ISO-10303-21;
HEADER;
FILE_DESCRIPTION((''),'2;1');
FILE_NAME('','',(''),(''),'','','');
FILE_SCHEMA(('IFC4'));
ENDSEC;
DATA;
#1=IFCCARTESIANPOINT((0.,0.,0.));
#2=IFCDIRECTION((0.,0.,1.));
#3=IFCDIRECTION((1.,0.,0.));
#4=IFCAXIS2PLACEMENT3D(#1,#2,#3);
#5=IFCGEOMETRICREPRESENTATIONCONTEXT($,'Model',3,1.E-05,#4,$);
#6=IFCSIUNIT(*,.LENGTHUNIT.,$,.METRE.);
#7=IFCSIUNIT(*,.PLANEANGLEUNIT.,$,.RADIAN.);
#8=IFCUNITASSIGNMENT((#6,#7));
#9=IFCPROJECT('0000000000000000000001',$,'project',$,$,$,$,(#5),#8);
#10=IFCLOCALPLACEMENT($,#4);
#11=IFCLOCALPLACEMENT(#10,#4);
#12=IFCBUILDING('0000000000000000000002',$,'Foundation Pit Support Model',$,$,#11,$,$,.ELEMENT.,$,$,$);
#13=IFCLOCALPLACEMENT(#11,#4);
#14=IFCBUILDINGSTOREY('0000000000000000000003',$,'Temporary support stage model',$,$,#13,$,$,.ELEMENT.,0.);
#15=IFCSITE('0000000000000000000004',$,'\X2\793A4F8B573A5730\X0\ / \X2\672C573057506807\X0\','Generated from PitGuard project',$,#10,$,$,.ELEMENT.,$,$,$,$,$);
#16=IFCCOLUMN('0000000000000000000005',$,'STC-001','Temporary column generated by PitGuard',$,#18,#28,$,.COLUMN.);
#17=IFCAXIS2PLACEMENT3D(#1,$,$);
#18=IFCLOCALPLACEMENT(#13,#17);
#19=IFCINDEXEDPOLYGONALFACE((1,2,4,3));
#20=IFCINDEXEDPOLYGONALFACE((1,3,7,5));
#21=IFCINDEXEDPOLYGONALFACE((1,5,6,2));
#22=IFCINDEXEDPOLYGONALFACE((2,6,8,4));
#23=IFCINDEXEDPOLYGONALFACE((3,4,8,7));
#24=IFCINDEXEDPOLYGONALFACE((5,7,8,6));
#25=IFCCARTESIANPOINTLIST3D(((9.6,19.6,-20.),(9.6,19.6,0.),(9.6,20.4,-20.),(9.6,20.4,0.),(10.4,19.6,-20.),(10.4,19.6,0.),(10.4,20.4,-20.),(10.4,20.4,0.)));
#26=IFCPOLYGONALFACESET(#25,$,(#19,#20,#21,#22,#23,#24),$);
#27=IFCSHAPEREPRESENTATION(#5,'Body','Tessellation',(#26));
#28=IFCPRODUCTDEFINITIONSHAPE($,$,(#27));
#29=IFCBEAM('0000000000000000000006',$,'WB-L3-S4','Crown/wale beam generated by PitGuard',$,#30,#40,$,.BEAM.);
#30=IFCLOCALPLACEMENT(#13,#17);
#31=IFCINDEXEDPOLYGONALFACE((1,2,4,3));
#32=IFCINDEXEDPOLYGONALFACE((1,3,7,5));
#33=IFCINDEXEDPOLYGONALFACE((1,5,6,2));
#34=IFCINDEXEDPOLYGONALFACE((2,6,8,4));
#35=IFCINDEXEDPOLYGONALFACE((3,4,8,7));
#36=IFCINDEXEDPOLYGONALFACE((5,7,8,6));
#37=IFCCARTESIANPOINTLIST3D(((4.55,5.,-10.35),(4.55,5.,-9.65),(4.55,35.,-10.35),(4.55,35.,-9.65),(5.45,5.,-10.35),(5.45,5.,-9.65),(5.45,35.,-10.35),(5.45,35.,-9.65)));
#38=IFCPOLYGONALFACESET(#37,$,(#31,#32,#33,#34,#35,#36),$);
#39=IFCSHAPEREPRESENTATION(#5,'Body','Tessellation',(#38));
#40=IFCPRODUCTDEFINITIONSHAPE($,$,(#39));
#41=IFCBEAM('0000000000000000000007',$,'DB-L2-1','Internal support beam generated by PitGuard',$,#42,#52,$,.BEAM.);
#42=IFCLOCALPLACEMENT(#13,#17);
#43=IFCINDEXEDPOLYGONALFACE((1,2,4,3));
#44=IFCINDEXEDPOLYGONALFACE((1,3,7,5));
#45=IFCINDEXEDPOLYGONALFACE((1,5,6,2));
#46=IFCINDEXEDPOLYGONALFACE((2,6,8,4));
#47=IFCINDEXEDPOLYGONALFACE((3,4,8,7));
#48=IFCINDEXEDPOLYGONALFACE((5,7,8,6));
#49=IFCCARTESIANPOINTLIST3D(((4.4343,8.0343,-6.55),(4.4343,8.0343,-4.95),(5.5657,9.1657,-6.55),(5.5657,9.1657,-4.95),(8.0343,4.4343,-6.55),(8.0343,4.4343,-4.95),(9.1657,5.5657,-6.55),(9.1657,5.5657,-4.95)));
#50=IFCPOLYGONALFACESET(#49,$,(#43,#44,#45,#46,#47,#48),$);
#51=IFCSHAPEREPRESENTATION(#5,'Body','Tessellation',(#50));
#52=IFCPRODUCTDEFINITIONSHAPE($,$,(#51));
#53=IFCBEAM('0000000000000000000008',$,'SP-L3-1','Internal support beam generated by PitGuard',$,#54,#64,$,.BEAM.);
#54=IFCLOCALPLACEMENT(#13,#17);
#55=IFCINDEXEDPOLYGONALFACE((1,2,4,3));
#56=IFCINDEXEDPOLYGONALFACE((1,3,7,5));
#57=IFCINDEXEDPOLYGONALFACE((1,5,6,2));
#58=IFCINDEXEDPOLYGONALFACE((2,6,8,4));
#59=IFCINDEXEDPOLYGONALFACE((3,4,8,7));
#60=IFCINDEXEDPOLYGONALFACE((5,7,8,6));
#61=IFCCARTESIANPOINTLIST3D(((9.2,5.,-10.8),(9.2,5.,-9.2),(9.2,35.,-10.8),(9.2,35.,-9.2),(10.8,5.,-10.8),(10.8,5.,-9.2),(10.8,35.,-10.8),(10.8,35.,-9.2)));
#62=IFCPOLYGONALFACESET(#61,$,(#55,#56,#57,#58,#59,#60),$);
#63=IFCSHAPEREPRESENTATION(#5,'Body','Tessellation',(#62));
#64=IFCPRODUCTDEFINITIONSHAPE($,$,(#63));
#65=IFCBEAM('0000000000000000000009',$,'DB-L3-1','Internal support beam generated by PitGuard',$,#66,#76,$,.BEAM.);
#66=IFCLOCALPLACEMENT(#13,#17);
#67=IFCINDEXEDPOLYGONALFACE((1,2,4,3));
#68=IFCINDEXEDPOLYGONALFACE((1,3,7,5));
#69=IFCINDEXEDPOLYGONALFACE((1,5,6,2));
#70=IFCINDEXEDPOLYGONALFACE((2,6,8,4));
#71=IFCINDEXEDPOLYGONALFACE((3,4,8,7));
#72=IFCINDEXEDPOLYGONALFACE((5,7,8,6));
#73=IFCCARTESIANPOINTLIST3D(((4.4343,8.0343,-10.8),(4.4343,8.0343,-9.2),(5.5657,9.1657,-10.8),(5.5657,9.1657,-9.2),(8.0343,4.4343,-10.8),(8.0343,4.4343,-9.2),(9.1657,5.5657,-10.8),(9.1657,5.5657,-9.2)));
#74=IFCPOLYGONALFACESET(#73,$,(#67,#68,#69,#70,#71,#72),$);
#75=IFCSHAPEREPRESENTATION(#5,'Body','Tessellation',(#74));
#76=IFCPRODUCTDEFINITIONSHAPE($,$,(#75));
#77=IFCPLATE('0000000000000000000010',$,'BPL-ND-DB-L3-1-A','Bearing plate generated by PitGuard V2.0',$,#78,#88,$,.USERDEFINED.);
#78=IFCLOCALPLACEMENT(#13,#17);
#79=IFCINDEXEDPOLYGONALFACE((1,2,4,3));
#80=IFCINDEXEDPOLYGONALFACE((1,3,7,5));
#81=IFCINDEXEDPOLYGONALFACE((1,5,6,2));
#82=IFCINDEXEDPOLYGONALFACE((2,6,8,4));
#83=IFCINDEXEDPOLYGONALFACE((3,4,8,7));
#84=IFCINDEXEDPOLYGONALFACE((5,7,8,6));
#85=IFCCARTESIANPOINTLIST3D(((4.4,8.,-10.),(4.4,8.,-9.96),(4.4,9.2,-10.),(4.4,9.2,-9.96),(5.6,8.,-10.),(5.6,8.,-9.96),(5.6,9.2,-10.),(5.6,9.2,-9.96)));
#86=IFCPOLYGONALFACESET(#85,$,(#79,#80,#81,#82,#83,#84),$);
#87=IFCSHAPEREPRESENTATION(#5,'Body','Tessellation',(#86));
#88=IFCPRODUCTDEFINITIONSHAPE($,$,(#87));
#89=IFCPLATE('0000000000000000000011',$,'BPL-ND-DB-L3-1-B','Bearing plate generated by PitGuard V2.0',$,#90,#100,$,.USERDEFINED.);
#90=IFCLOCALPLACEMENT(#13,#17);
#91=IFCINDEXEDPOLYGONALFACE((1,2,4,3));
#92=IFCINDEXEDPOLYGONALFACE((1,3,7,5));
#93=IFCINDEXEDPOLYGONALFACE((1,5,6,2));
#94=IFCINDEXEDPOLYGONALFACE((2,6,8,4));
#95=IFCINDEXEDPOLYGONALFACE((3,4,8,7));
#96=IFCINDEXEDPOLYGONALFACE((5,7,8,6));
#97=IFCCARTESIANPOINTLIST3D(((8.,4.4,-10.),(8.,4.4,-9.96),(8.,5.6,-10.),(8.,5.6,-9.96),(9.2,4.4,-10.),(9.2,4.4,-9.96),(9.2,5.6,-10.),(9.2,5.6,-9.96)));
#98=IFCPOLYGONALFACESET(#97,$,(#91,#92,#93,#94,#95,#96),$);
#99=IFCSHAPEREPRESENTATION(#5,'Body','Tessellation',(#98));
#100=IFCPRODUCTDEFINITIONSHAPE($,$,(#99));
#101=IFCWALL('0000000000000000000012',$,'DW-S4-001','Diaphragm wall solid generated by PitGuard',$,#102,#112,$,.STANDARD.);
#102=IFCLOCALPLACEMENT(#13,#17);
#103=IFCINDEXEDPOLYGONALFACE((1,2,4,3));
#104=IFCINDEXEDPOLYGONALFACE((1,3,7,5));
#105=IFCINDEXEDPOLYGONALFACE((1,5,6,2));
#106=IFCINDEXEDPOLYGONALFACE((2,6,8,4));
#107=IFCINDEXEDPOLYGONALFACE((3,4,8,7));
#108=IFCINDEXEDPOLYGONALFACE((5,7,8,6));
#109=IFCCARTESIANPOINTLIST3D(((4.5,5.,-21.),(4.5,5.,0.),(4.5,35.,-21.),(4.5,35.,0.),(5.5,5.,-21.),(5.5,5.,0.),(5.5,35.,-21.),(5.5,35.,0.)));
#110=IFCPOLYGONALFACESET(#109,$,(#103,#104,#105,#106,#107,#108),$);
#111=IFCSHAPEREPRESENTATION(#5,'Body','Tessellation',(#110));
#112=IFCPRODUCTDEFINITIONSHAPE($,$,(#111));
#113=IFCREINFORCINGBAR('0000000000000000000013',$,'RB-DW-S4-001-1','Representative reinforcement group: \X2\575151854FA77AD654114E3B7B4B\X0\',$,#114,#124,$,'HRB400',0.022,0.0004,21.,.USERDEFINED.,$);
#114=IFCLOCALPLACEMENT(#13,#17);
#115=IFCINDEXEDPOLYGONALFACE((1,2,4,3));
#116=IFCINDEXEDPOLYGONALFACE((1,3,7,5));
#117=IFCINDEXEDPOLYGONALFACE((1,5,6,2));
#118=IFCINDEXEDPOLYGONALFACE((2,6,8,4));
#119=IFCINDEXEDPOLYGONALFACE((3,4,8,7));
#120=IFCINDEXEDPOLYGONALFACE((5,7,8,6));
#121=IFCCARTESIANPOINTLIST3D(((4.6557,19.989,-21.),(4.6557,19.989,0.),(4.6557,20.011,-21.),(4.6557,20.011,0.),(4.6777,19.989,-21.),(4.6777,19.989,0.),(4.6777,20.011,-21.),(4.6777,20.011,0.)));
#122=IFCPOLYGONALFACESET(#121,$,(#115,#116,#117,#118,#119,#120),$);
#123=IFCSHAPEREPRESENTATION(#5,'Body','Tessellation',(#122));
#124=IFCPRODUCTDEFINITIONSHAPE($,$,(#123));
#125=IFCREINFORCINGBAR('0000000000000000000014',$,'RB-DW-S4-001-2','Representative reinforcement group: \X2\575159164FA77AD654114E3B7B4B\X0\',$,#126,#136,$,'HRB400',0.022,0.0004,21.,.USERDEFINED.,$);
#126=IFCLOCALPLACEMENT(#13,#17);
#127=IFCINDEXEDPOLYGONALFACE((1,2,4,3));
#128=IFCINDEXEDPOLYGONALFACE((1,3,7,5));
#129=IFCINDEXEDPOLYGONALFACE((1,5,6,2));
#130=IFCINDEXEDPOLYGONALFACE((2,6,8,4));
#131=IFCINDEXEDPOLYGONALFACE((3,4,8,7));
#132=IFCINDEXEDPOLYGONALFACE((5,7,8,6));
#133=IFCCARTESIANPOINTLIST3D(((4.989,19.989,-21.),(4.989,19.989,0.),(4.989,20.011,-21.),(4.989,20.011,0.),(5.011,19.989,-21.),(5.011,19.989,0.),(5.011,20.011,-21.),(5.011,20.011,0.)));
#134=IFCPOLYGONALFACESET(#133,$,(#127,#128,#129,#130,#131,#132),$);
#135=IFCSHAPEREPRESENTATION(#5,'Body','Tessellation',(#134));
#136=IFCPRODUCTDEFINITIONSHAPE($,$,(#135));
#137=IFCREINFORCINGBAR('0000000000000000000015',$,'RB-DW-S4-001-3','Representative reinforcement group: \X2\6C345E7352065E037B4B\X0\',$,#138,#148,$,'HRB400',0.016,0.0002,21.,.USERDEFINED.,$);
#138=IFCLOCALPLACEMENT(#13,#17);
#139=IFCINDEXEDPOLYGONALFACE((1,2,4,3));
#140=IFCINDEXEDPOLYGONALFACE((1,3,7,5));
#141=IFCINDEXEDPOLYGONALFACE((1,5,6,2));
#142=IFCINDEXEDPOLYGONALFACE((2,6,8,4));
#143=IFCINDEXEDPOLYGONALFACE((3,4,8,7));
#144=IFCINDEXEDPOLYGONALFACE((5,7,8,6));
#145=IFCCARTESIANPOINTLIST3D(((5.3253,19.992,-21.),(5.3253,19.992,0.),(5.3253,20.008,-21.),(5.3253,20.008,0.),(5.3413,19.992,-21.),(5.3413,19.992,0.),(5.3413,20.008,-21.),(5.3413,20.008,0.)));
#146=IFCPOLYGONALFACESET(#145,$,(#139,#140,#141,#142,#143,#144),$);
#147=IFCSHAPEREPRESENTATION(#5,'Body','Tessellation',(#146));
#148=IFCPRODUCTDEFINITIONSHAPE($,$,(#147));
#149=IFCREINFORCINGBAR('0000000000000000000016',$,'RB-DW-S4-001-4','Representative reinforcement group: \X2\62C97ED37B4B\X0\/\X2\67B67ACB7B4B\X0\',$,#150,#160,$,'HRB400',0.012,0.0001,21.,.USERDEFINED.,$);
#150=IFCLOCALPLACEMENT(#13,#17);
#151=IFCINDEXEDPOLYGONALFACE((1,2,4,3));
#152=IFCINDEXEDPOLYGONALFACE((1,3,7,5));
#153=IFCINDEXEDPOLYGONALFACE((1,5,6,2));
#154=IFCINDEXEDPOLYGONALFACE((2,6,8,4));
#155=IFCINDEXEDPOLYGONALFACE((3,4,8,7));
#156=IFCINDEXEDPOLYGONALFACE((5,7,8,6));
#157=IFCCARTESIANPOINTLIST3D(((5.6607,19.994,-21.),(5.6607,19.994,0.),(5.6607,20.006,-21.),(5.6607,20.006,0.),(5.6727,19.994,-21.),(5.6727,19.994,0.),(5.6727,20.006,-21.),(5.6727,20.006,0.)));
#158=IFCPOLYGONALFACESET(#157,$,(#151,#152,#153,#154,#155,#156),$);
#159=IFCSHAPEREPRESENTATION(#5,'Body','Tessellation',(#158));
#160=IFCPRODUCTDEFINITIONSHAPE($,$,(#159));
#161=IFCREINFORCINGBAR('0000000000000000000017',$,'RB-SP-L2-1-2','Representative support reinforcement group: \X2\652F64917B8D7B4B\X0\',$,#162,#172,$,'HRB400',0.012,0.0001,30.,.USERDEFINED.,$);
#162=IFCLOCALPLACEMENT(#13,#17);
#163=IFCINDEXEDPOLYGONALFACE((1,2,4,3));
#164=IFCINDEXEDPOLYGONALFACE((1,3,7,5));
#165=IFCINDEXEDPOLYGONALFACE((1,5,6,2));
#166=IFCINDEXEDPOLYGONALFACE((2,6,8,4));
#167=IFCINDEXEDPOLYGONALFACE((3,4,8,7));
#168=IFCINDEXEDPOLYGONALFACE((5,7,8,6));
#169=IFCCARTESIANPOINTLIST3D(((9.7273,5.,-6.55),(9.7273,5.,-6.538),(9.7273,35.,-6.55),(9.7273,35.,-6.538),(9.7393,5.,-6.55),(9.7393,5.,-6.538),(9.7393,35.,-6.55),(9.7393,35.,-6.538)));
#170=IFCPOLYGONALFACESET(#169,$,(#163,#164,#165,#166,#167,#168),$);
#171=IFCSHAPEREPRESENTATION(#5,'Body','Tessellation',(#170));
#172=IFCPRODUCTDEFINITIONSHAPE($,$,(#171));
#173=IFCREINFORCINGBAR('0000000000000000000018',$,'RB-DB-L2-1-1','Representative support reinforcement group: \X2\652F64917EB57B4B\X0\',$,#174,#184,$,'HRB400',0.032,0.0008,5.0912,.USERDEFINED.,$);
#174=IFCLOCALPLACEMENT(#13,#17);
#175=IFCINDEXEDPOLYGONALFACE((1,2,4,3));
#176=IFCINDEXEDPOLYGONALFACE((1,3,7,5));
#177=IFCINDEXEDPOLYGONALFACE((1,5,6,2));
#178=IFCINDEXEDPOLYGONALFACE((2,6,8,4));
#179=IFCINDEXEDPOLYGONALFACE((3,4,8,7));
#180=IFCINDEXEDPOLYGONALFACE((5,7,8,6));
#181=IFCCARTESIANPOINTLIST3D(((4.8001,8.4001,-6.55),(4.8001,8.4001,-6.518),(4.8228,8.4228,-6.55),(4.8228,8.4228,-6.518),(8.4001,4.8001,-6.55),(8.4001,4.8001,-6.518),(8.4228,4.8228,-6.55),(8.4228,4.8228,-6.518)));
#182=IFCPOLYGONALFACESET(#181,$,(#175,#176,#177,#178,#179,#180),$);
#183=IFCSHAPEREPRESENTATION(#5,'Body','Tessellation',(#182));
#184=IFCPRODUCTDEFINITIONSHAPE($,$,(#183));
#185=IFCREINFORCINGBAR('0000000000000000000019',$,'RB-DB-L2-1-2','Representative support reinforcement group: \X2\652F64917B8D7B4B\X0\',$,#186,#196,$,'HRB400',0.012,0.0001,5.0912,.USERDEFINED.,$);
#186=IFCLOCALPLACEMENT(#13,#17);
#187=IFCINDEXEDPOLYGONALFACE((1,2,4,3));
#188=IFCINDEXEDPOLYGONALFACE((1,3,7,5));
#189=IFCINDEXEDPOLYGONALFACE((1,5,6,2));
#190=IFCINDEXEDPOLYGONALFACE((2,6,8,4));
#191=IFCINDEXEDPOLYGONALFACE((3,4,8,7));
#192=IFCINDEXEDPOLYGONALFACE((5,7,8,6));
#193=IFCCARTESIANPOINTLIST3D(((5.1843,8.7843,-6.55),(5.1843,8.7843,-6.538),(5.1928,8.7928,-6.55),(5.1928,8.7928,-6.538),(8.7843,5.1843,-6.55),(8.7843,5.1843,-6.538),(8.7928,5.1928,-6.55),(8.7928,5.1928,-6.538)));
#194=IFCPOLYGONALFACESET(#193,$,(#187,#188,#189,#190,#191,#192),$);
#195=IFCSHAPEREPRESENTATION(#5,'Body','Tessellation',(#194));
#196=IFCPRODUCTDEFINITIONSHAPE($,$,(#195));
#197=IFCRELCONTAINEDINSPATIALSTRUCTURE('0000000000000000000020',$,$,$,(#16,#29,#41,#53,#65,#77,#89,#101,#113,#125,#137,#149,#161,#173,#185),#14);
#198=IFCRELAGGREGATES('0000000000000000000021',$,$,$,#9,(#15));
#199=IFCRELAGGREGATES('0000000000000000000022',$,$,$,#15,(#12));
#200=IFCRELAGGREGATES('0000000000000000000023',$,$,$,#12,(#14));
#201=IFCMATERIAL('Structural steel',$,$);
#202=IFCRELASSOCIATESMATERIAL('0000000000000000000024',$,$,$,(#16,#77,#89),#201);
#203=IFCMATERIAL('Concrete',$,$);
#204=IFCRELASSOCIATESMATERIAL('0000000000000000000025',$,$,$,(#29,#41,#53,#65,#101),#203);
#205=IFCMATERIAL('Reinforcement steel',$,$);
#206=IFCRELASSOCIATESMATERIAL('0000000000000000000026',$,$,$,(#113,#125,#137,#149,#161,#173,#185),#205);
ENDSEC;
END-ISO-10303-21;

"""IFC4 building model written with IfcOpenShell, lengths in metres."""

from ifc_helpers import new_model, si_unit, frame, origin_with_axes, origin_2d, place, context, project, spatial, rectangle, extrude, material, element, save


model = new_model("IFC4")

# Units and contexts
model_context = context("Model", 3, precision=1e-05, world=origin_with_axes())
ifc_project = project(units=[si_unit("LENGTHUNIT", "METRE"), si_unit("PLANEANGLEUNIT", "RADIAN")], contexts=[model_context])

# Site, building, storey
site_placement = place(None, origin_with_axes())
site = spatial("IfcSite", under=ifc_project, at=site_placement, Name="示例场地 / 本地坐标", Description="Generated from PitGuard project", CompositionType="ELEMENT")
building_placement = place(site_placement, origin_with_axes())
building = spatial("IfcBuilding", under=site, at=building_placement, Name="Foundation Pit Support Model", CompositionType="ELEMENT")
storey_placement = place(building_placement, origin_with_axes())
storey = spatial("IfcBuildingStorey", under=building, at=storey_placement, Name="Temporary support stage model", CompositionType="ELEMENT", Elevation=0.0)

# Column
ifc_material_1 = material(Name="Structural steel")
column_placement = place(storey_placement, frame((10.0, 20.0, -20.0), z_axis=(0.0, 0.0, 1.0), x_axis=(1.0, 0.0, 0.0)))
element("IfcColumn", 1, at=column_placement, inside=storey, material=ifc_material_1, Name="STC-001", Description="Temporary column generated by PitGuard", PredefinedType="COLUMN", context=model_context, shape_type="SweptSolid", body=[
    extrude(rectangle(XDim=0.8, YDim=0.8, at=origin_2d()), origin_with_axes(), (0.0, 0.0, 1.0), 20.0),
])

# Beams
ifc_material_2 = material(Name="Concrete")
beam_1_placement = place(storey_placement, frame((5.0, 20.0, -10.35), z_axis=(0.0, 0.0, 1.0), x_axis=(0.0, -1.0, 0.0)))
element("IfcBeam", 2, at=beam_1_placement, inside=storey, material=ifc_material_2, Name="WB-L3-S4", Description="Crown/wale beam generated by PitGuard", PredefinedType="BEAM", context=model_context, shape_type="SweptSolid", body=[
    extrude(rectangle(XDim=30.0, YDim=0.9, at=origin_2d()), origin_with_axes(), (0.0, 0.0, 1.0), 0.7),
])
beam_2_placement = place(storey_placement, frame((6.8, 6.8, -6.55), z_axis=(0.0, 0.0, 1.0), x_axis=(0.707107, -0.707107, 0.0)))
element("IfcBeam", 3, at=beam_2_placement, inside=storey, material=ifc_material_2, Name="DB-L2-1", Description="Internal support beam generated by PitGuard", PredefinedType="BEAM", context=model_context, shape_type="SweptSolid", body=[
    extrude(rectangle(XDim=5.0912, YDim=1.6, at=origin_2d()), origin_with_axes(), (0.0, 0.0, 1.0), 1.6),
])
beam_3_placement = place(storey_placement, frame((10.0, 20.0, -10.8), z_axis=(0.0, 0.0, 1.0), x_axis=(0.0, 1.0, 0.0)))
element("IfcBeam", 4, at=beam_3_placement, inside=storey, material=ifc_material_2, Name="SP-L3-1", Description="Internal support beam generated by PitGuard", PredefinedType="BEAM", context=model_context, shape_type="SweptSolid", body=[
    extrude(rectangle(XDim=30.0, YDim=1.6, at=origin_2d()), origin_with_axes(), (0.0, 0.0, 1.0), 1.6),
])
beam_4_placement = place(storey_placement, frame((6.8, 6.8, -10.8), z_axis=(0.0, 0.0, 1.0), x_axis=(0.707107, -0.707107, 0.0)))
element("IfcBeam", 5, at=beam_4_placement, inside=storey, material=ifc_material_2, Name="DB-L3-1", Description="Internal support beam generated by PitGuard", PredefinedType="BEAM", context=model_context, shape_type="SweptSolid", body=[
    extrude(rectangle(XDim=5.0912, YDim=1.6, at=origin_2d()), origin_with_axes(), (0.0, 0.0, 1.0), 1.6),
])

# Plates
for number, where, z_axis, x_axis, name in (
    (6, (5.0, 8.6, -10.0), (0.0, 0.0, 1.0), (1.0, 0.0, 0.0), "BPL-ND-DB-L3-1-A"),
    (7, (8.6, 5.0, -10.0), (0.0, 0.0, 1.0), (1.0, 0.0, 0.0), "BPL-ND-DB-L3-1-B"),
):
    element("IfcPlate", number, at=place(storey_placement, frame(where, z_axis=z_axis, x_axis=x_axis)), inside=storey, material=ifc_material_1, Name=name, Description="Bearing plate generated by PitGuard V2.0", PredefinedType="USERDEFINED", context=model_context, shape_type="SweptSolid", body=[
        extrude(rectangle(XDim=1.2, YDim=1.2, at=origin_2d()), origin_with_axes(), (0.0, 0.0, 1.0), 0.04),
    ])

# Wall
wall_placement = place(storey_placement, frame((5.0, 20.0, -21.0), z_axis=(0.0, 0.0, 1.0), x_axis=(0.0, -1.0, 0.0)))
element("IfcWall", 8, at=wall_placement, inside=storey, material=ifc_material_2, Name="DW-S4-001", Description="Diaphragm wall solid generated by PitGuard", PredefinedType="STANDARD", context=model_context, shape_type="SweptSolid", body=[
    extrude(rectangle(XDim=30.0, YDim=1.0, at=origin_2d()), origin_with_axes(), (0.0, 0.0, 1.0), 21.0),
])

# Reinforcing bars
ifc_material_3 = material(Name="Reinforcement steel")
for number, where, z_axis, x_axis, name, description in (
    (9, (4.6667, 20.0, -21.0), (0.0, 0.0, 1.0), (1.0, 0.0, 0.0), "RB-DW-S4-001-1", "Representative reinforcement group: 坑内侧竖向主筋"),
    (10, (5.0, 20.0, -21.0), (0.0, 0.0, 1.0), (1.0, 0.0, 0.0), "RB-DW-S4-001-2", "Representative reinforcement group: 坑外侧竖向主筋"),
):
    element("IfcReinforcingBar", number, at=place(storey_placement, frame(where, z_axis=z_axis, x_axis=x_axis)), inside=storey, material=ifc_material_3, Name=name, Description=description, SteelGrade="HRB400", BarLength=21.0, CrossSectionArea=0.0004, NominalDiameter=0.022, PredefinedType="USERDEFINED", context=model_context, shape_type="SweptSolid", body=[
        extrude(rectangle(XDim=0.022, YDim=0.022, at=origin_2d()), origin_with_axes(), (0.0, 0.0, 1.0), 21.0),
    ])
reinforcing_bar_1_placement = place(storey_placement, frame((5.3333, 20.0, -21.0), z_axis=(0.0, 0.0, 1.0), x_axis=(1.0, 0.0, 0.0)))
element("IfcReinforcingBar", 11, at=reinforcing_bar_1_placement, inside=storey, material=ifc_material_3, Name="RB-DW-S4-001-3", Description="Representative reinforcement group: 水平分布筋", SteelGrade="HRB400", BarLength=21.0, CrossSectionArea=0.0002, NominalDiameter=0.016, PredefinedType="USERDEFINED", context=model_context, shape_type="SweptSolid", body=[
    extrude(rectangle(XDim=0.016, YDim=0.016, at=origin_2d()), origin_with_axes(), (0.0, 0.0, 1.0), 21.0),
])
reinforcing_bar_2_placement = place(storey_placement, frame((5.6667, 20.0, -21.0), z_axis=(0.0, 0.0, 1.0), x_axis=(1.0, 0.0, 0.0)))
element("IfcReinforcingBar", 12, at=reinforcing_bar_2_placement, inside=storey, material=ifc_material_3, Name="RB-DW-S4-001-4", Description="Representative reinforcement group: 拉结筋/架立筋", SteelGrade="HRB400", BarLength=21.0, CrossSectionArea=0.0001, NominalDiameter=0.012, PredefinedType="USERDEFINED", context=model_context, shape_type="SweptSolid", body=[
    extrude(rectangle(XDim=0.012, YDim=0.012, at=origin_2d()), origin_with_axes(), (0.0, 0.0, 1.0), 21.0),
])
reinforcing_bar_3_placement = place(storey_placement, frame((9.7333, 20.0, -6.55), z_axis=(0.0, 0.0, 1.0), x_axis=(0.0, 1.0, 0.0)))
element("IfcReinforcingBar", 13, at=reinforcing_bar_3_placement, inside=storey, material=ifc_material_3, Name="RB-SP-L2-1-2", Description="Representative support reinforcement group: 支撑箍筋", SteelGrade="HRB400", BarLength=30.0, CrossSectionArea=0.0001, NominalDiameter=0.012, PredefinedType="USERDEFINED", context=model_context, shape_type="SweptSolid", body=[
    extrude(rectangle(XDim=30.0, YDim=0.012, at=origin_2d()), origin_with_axes(), (0.0, 0.0, 1.0), 0.012),
])
reinforcing_bar_4_placement = place(storey_placement, frame((6.6114, 6.6114, -6.55), z_axis=(0.0, 0.0, 1.0), x_axis=(0.707107, -0.707107, 0.0)))
element("IfcReinforcingBar", 14, at=reinforcing_bar_4_placement, inside=storey, material=ifc_material_3, Name="RB-DB-L2-1-1", Description="Representative support reinforcement group: 支撑纵筋", SteelGrade="HRB400", BarLength=5.0912, CrossSectionArea=0.0008, NominalDiameter=0.032, PredefinedType="USERDEFINED", context=model_context, shape_type="SweptSolid", body=[
    extrude(rectangle(XDim=5.0912, YDim=0.032, at=origin_2d()), origin_with_axes(), (0.0, 0.0, 1.0), 0.032),
])
reinforcing_bar_5_placement = place(storey_placement, frame((6.9886, 6.9886, -6.55), z_axis=(0.0, 0.0, 1.0), x_axis=(0.707107, -0.707107, 0.0)))
element("IfcReinforcingBar", 15, at=reinforcing_bar_5_placement, inside=storey, material=ifc_material_3, Name="RB-DB-L2-1-2", Description="Representative support reinforcement group: 支撑箍筋", SteelGrade="HRB400", BarLength=5.0912, CrossSectionArea=0.0001, NominalDiameter=0.012, PredefinedType="USERDEFINED", context=model_context, shape_type="SweptSolid", body=[
    extrude(rectangle(XDim=5.0912, YDim=0.012, at=origin_2d()), origin_with_axes(), (0.0, 0.0, 1.0), 0.012),
])

save(model, "model.ifc")
